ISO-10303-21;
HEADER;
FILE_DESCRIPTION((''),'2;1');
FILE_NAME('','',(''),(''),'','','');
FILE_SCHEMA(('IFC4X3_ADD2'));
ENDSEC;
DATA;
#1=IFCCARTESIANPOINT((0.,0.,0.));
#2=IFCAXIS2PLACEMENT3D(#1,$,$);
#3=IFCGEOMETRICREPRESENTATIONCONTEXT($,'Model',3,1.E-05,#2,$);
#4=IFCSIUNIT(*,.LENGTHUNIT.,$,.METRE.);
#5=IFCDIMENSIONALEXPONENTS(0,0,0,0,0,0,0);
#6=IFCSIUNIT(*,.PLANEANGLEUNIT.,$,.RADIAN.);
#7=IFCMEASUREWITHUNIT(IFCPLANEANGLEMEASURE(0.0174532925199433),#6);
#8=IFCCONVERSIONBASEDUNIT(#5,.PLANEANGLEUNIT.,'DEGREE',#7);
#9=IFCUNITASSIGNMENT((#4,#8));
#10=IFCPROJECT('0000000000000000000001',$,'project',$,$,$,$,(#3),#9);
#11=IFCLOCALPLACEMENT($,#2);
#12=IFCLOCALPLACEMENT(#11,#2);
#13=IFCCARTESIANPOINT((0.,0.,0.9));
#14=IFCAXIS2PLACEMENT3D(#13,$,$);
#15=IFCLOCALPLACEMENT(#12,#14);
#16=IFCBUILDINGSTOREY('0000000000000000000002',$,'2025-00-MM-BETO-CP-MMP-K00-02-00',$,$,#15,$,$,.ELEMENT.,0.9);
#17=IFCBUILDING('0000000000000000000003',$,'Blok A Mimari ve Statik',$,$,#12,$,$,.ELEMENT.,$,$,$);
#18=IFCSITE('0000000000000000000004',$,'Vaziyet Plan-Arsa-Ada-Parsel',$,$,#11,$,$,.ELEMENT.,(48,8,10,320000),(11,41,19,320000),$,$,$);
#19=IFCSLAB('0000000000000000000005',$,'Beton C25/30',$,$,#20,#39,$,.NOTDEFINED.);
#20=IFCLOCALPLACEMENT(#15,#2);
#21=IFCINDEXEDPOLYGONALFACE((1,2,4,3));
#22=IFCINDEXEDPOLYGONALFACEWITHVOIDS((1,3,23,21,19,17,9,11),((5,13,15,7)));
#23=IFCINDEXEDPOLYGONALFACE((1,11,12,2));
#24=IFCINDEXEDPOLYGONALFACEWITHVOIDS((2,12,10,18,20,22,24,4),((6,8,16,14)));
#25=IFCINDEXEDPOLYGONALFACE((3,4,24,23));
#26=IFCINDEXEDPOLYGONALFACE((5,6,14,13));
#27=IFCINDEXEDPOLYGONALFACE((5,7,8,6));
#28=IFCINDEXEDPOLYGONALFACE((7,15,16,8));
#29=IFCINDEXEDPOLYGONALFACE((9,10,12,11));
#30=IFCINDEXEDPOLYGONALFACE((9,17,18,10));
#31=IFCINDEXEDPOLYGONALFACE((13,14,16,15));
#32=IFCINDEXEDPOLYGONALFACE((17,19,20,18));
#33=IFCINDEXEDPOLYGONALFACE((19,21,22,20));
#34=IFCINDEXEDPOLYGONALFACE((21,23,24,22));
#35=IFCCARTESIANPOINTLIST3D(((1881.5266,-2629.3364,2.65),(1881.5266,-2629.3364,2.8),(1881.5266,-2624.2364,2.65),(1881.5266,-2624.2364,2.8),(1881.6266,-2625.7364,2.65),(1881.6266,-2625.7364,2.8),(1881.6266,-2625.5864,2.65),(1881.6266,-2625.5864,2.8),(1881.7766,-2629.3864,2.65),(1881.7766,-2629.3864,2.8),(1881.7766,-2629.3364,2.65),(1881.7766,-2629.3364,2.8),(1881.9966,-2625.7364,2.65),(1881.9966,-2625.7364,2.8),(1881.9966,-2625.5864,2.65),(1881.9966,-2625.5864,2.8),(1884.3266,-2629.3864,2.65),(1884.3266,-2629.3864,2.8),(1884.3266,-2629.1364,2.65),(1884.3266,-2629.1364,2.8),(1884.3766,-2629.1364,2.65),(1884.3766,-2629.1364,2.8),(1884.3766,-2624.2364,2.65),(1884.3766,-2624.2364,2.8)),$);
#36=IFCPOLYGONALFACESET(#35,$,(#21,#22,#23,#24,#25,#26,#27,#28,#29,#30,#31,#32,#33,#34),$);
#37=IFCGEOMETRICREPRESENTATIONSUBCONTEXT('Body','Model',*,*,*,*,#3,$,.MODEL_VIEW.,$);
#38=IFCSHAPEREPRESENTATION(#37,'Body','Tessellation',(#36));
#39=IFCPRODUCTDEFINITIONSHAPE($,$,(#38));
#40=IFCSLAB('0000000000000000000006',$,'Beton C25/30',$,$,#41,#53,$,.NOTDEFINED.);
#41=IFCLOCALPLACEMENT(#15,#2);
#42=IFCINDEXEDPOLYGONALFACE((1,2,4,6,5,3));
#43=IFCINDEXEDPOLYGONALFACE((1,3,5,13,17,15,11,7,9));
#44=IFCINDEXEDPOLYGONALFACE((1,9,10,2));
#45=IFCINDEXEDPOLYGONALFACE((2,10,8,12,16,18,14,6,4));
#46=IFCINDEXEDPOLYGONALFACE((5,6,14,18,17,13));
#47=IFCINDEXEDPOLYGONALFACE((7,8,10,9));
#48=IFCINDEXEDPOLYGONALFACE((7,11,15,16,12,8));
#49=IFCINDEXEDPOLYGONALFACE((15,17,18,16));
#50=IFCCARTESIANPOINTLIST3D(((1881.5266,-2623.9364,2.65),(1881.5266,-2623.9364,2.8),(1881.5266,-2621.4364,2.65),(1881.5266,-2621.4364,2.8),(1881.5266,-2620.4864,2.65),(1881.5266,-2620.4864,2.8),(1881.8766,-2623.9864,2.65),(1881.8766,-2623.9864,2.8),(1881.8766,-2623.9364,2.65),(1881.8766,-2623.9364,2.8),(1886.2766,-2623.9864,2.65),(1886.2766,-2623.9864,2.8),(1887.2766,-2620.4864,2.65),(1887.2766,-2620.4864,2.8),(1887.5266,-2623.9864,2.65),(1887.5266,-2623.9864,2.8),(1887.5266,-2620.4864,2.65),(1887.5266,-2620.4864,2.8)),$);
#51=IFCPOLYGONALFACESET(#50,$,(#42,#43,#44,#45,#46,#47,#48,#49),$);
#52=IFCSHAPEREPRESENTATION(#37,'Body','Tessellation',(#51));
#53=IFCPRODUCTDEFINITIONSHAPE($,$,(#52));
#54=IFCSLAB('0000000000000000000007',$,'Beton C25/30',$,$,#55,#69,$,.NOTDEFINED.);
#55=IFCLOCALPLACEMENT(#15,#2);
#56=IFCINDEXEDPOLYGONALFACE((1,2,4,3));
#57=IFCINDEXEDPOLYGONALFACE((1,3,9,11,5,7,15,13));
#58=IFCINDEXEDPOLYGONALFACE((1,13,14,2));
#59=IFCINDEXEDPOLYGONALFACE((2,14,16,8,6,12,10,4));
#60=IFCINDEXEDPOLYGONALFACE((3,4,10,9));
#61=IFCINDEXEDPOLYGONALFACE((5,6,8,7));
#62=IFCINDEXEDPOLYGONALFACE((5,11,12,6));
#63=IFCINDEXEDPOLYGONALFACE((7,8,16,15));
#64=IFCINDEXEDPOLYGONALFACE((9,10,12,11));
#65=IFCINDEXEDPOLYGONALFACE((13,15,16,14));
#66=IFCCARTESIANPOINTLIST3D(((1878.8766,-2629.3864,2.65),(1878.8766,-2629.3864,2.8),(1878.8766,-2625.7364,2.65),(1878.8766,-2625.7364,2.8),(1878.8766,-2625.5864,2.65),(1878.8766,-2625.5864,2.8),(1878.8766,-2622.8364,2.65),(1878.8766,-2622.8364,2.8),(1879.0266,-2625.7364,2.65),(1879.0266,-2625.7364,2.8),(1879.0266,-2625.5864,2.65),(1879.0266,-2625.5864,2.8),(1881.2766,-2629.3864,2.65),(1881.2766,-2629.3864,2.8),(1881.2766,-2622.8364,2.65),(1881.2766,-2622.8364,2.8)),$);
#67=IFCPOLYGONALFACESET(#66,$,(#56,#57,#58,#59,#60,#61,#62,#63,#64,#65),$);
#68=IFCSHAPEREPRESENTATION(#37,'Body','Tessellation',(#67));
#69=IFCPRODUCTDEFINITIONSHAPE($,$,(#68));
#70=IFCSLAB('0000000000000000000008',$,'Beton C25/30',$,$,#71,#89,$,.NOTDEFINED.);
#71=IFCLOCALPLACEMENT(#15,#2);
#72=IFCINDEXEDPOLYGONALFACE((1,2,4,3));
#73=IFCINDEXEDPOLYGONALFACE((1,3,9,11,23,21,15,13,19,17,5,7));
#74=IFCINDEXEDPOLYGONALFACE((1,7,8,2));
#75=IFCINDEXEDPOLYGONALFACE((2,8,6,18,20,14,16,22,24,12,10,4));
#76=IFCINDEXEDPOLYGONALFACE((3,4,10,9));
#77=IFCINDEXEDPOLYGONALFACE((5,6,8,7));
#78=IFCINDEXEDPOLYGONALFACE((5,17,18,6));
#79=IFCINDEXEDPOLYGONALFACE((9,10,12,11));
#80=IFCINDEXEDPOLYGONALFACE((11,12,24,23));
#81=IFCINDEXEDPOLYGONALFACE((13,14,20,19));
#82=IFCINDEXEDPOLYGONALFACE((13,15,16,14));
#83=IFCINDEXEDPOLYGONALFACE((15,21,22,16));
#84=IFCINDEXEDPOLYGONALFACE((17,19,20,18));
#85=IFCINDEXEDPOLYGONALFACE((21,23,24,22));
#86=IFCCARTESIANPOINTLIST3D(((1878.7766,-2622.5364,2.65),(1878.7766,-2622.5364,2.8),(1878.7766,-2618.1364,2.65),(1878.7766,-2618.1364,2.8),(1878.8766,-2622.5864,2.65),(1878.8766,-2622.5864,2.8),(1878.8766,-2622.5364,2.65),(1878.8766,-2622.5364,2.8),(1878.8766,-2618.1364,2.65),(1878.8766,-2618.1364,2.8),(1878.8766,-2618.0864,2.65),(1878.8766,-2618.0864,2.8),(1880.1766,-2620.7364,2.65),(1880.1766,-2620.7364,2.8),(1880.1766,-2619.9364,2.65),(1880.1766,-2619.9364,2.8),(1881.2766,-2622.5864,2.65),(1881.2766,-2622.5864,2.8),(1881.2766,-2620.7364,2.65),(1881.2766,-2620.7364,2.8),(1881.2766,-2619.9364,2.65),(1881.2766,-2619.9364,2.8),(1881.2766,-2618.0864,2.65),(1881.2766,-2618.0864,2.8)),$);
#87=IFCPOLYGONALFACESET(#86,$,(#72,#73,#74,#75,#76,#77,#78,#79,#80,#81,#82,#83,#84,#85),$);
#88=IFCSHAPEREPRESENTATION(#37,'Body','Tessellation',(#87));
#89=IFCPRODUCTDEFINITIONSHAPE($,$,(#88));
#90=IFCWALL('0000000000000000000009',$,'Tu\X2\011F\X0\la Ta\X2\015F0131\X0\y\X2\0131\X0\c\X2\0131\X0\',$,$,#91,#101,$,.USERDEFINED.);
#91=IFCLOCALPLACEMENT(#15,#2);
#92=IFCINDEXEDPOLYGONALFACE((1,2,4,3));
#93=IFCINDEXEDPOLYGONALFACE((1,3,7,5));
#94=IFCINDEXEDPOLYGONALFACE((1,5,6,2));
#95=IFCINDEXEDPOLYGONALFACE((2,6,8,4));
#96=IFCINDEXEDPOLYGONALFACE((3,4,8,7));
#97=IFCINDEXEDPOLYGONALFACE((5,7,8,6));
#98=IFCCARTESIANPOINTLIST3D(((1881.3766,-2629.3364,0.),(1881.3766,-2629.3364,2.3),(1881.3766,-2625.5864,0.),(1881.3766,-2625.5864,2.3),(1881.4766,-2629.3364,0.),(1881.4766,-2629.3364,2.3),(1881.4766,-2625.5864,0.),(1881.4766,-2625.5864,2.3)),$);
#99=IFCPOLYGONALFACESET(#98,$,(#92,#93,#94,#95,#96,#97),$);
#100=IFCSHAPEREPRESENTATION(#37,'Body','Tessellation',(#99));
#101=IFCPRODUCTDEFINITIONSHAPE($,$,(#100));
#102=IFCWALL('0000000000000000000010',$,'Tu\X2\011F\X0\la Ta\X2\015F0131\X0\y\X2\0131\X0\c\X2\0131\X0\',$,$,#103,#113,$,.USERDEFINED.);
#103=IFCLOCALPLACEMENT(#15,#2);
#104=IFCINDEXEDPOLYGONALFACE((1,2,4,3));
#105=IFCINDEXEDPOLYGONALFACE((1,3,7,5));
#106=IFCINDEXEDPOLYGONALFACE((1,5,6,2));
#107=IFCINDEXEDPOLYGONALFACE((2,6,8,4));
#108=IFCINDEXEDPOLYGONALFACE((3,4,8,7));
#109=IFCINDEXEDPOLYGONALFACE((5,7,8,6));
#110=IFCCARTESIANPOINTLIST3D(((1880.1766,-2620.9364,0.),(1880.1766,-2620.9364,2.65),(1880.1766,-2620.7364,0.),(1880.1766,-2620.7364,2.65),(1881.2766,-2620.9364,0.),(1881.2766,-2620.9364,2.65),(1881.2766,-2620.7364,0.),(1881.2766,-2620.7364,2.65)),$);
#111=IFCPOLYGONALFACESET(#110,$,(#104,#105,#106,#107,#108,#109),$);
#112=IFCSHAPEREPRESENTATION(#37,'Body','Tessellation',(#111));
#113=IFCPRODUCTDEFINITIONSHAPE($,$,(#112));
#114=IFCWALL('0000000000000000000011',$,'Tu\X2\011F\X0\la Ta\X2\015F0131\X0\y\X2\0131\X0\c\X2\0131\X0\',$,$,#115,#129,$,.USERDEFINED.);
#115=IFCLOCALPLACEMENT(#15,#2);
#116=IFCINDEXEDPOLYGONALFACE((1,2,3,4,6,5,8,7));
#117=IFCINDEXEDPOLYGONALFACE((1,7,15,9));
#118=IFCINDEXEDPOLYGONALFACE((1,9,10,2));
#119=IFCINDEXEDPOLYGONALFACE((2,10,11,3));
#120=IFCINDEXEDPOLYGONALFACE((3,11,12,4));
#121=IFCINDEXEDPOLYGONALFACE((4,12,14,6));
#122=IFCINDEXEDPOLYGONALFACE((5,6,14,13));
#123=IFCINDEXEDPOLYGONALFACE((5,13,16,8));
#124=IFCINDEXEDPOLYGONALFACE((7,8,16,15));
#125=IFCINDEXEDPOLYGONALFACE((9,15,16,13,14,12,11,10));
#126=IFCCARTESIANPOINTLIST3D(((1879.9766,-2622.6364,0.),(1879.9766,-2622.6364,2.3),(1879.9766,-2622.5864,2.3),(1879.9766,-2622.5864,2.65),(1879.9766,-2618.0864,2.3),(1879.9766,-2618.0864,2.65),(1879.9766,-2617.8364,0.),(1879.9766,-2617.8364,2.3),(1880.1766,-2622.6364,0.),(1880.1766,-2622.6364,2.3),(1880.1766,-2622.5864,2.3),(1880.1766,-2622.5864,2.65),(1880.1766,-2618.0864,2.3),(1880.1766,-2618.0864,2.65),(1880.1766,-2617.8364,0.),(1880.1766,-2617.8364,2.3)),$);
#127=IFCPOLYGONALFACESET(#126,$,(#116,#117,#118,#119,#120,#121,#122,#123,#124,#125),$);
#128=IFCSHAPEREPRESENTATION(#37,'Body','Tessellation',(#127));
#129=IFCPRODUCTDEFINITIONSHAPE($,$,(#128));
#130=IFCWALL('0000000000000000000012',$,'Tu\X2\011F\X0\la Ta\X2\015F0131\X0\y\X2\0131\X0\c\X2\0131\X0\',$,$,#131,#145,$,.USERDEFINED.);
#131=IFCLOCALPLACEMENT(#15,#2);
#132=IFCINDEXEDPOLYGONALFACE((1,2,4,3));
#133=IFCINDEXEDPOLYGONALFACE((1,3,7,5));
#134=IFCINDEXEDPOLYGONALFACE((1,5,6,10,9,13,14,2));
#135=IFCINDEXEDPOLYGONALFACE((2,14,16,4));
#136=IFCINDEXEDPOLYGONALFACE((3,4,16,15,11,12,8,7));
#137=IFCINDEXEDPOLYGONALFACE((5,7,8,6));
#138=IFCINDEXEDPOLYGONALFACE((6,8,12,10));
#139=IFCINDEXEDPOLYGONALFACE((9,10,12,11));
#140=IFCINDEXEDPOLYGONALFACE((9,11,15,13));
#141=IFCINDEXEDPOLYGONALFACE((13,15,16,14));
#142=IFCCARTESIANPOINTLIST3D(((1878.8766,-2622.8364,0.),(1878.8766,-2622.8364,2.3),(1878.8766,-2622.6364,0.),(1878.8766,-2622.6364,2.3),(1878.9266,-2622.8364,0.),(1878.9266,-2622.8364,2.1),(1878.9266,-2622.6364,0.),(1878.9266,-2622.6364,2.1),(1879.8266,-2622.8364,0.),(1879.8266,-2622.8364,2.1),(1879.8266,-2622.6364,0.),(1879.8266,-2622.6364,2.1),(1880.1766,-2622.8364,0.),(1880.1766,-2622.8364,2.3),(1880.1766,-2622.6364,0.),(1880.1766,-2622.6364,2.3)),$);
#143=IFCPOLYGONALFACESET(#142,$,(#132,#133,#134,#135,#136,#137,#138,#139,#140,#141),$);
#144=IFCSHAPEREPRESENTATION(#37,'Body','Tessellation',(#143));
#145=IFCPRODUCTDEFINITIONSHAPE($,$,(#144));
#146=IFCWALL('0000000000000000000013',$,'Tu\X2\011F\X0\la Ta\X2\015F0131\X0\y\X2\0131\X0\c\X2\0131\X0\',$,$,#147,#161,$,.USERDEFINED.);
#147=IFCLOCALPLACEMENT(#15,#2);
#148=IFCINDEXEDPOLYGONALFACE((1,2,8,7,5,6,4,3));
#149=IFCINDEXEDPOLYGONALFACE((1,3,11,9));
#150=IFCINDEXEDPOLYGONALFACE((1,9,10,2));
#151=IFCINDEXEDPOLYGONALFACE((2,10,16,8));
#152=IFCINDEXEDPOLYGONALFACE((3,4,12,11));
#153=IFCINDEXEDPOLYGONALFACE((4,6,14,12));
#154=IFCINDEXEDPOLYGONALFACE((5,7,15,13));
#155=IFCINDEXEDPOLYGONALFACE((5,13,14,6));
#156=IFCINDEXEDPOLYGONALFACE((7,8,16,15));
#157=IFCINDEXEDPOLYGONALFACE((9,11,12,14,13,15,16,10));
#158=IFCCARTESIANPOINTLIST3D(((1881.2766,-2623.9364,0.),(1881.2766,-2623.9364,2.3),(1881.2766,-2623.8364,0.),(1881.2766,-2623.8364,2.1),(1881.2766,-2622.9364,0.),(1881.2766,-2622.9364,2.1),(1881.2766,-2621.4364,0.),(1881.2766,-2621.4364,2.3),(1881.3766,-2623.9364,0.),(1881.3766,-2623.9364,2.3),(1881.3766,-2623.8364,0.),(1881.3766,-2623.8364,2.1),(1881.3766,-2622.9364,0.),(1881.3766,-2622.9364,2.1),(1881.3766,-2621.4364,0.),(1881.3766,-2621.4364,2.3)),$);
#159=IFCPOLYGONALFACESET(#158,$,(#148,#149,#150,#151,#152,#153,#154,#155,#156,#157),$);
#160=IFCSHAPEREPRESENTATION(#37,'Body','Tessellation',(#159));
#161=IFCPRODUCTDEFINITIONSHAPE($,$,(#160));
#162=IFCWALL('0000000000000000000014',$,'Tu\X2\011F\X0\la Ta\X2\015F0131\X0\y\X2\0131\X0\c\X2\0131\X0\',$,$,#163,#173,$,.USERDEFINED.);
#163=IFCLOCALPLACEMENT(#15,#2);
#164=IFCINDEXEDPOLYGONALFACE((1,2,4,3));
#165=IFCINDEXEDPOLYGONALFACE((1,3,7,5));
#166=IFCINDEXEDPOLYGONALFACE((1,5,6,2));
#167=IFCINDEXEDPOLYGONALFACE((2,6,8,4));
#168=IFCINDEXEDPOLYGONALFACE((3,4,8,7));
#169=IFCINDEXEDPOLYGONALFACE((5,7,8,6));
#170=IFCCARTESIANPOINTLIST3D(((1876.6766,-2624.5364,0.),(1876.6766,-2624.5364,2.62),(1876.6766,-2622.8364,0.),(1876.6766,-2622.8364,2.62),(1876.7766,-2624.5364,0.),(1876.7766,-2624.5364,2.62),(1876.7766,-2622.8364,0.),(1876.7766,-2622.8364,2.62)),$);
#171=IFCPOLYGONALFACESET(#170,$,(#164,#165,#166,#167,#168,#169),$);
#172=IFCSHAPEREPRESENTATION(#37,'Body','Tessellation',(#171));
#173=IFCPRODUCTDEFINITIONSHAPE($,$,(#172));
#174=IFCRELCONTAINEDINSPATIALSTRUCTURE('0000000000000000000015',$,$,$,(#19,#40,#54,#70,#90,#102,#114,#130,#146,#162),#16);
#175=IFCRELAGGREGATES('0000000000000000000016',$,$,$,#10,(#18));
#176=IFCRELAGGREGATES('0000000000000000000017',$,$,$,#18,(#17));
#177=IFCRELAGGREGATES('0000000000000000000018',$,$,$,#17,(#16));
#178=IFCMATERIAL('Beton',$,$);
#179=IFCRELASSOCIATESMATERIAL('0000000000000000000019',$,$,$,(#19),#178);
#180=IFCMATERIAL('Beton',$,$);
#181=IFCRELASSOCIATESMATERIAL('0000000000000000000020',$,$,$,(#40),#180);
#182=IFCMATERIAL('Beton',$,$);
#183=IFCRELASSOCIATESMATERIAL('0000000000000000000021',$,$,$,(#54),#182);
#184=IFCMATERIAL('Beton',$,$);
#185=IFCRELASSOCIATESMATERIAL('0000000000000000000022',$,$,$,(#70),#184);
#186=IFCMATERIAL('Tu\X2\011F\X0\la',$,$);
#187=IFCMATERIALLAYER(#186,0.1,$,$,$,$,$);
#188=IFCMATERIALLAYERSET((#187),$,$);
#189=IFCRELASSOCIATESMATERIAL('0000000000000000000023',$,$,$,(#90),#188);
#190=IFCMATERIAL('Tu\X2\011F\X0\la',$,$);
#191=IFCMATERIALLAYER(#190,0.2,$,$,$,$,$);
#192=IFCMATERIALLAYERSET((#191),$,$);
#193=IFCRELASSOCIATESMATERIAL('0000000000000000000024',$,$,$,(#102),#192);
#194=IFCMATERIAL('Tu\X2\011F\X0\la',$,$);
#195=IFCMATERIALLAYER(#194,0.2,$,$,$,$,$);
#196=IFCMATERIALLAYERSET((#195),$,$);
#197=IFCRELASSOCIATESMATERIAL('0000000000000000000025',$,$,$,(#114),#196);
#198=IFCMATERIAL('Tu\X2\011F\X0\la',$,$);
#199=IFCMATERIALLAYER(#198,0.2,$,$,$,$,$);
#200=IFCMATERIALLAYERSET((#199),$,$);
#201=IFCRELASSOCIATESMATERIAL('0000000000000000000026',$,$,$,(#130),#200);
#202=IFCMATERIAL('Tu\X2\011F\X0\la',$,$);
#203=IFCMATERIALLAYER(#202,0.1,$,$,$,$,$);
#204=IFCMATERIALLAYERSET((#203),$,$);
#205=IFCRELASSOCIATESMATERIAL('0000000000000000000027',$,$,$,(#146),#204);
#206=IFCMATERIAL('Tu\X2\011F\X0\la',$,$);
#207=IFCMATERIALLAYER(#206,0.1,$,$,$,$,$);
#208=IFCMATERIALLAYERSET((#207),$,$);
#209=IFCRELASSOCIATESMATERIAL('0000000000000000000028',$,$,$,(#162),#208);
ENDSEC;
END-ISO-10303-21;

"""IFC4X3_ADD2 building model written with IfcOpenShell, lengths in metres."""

from ifc_helpers import new_model, entity, si_unit, converted_unit, frame, frame_2d, origin, origin_with_axes, place, context, subcontext, project, spatial, polyline, rectangle, outline, extrude, clip, bounded_halfspace, material, layer, layer_set, layer_usage, element, save


model = new_model("IFC4X3_ADD2")

# Units and contexts
model_context = context("Model", 3, precision=1e-05, world=origin())
body_context = subcontext(model_context, "Body", "Model", "MODEL_VIEW")
ifc_project = project(units=[si_unit("LENGTHUNIT", "METRE"), converted_unit("PLANEANGLEUNIT", "DEGREE", entity("IfcPlaneAngleMeasure", 0.0174532925199433), si_unit("PLANEANGLEUNIT", "RADIAN"), dimensions=[0, 0, 0, 0, 0, 0, 0])], contexts=[model_context])

# Site, building, storey
site_placement = place(None, origin())
site = spatial("IfcSite", under=ifc_project, at=site_placement, Name="Vaziyet Plan-Arsa-Ada-Parsel", CompositionType="ELEMENT", RefLatitude=(48, 8, 10, 320000), RefLongitude=(11, 41, 19, 320000))
building_placement = place(site_placement, origin())
building = spatial("IfcBuilding", under=site, at=building_placement, Name="Blok A Mimari ve Statik", CompositionType="ELEMENT")
storey_placement = place(building_placement, frame((0.0, 0.0, 0.9)))
storey = spatial("IfcBuildingStorey", under=building, at=storey_placement, Name="2025-00-MM-BETO-CP-MMP-K00-02-00", CompositionType="ELEMENT", Elevation=0.9)

# Slabs
ifc_material_1 = material(Name="Beton")
slab_1_placement = place(storey_placement, frame((1881.5266, -2629.3864, 2.65)))
element("IfcSlab", 1, at=slab_1_placement, inside=storey, material=ifc_material_1, Name="Beton C25/30", PredefinedType="NOTDEFINED", context=body_context, shape_type="SweptSolid", body=[
    extrude(outline(polyline([(0.0, 5.15), (0.0, 0.05), (0.25, 0.05), (0.25, 0.0), (2.8, 0.0), (2.8, 0.25), (2.85, 0.25), (2.85, 5.15), (0.0, 5.15)]), holes=[polyline([(0.1, 3.8), (0.47, 3.8), (0.47, 3.65), (0.1, 3.65), (0.1, 3.8)])]), origin_with_axes(), (0.0, 0.0, 1.0), 0.15),
])
ifc_material_2 = material(Name="Beton")
slab_2_placement = place(storey_placement, frame((1881.5266, -2623.9864, 2.65)))
element("IfcSlab", 2, at=slab_2_placement, inside=storey, material=ifc_material_2, Name="Beton C25/30", PredefinedType="NOTDEFINED", context=body_context, shape_type="SweptSolid", body=[
    extrude(outline(polyline([(0.0, 3.5), (0.0, 2.55), (0.0, 0.05), (0.35, 0.05), (0.35, 0.0), (4.75, 0.0), (6.0, 0.0), (6.0, 3.5), (5.75, 3.5), (0.0, 3.5)])), origin_with_axes(), (0.0, 0.0, 1.0), 0.15),
])
ifc_material_3 = material(Name="Beton")
slab_3_placement = place(storey_placement, frame((1878.8766, -2629.3864, 2.65)))
element("IfcSlab", 3, at=slab_3_placement, inside=storey, material=ifc_material_3, Name="Beton C25/30", PredefinedType="NOTDEFINED", context=body_context, shape_type="SweptSolid", body=[
    extrude(outline(polyline([(0.0, 3.8), (0.15, 3.8), (0.15, 3.65), (0.0, 3.65), (0.0, 0.0), (2.4, 0.0), (2.4, 6.55), (0.0, 6.55), (0.0, 3.8)])), origin_with_axes(), (0.0, 0.0, 1.0), 0.15),
])

# Slab, opening
ifc_material_4 = material(Name="Beton")
slab_4_placement = place(storey_placement, frame((1878.7766, -2622.5864, 2.65)))
slab_4 = element("IfcSlab", 4, at=slab_4_placement, inside=storey, material=ifc_material_4, Name="Beton C25/30", PredefinedType="NOTDEFINED", context=body_context, shape_type="SweptSolid", body=[
    extrude(outline(polyline([(0.1, 4.45), (0.0, 4.45), (0.0, 0.05), (0.1, 0.05), (0.1, 0.0), (2.5, 0.0), (2.5, 4.5), (0.1, 4.5), (0.1, 4.45)])), origin_with_axes(), (0.0, 0.0, 1.0), 0.15),
])
opening_1_placement = place(slab_4_placement, frame((1.4, 1.85, 0.0)))
element("IfcOpeningElement", 5, at=opening_1_placement, cuts=slab_4, PredefinedType="OPENING", context=body_context, shape_type="SweptSolid", body=[
    extrude(rectangle(XDim=1.1, YDim=0.8, at=frame_2d((0.0, 0.0), x_axis=(-1.0, 0.0))), frame((0.55, 0.4, 0.0), z_axis=(0.0, 0.0, 1.0), x_axis=(1.0, 0.0, 0.0)), (0.0, 0.0, 1.0), 0.15),
])

# Walls
ifc_material_5 = material(Name="Tuğla")
ifc_layer_1 = layer(ifc_material_5, 0.1)
ifc_layer_set_1 = layer_set([ifc_layer_1])
ifc_layer_usage_1 = layer_usage(ifc_layer_set_1, "AXIS2", "POSITIVE", 0.0)
wall_1_placement = place(storey_placement, frame((1881.3766, -2625.5864, 0.0), z_axis=(0.0, 0.0, 1.0), x_axis=(0.0, -1.0, 0.0)))
element("IfcWall", 6, at=wall_1_placement, inside=storey, material=ifc_layer_usage_1, Name="Tuğla Taşıyıcı", PredefinedType="USERDEFINED", context=body_context, shape_type="SweptSolid", body=[
    extrude(rectangle(XDim=3.75, YDim=0.1, at=frame_2d((1.875, 0.05), x_axis=(1.0, 0.0))), origin_with_axes(), (0.0, 0.0, 1.0), 2.3),
])
ifc_material_6 = material(Name="Tuğla")
ifc_layer_2 = layer(ifc_material_6, 0.2)
ifc_layer_set_2 = layer_set([ifc_layer_2])
ifc_layer_usage_2 = layer_usage(ifc_layer_set_2, "AXIS2", "POSITIVE", 0.0)
wall_2_placement = place(storey_placement, frame((1880.1766, -2620.9364, 0.0)))
element("IfcWall", 7, at=wall_2_placement, inside=storey, material=ifc_layer_usage_2, Name="Tuğla Taşıyıcı", PredefinedType="USERDEFINED", context=body_context, shape_type="SweptSolid", body=[
    extrude(rectangle(XDim=1.1, YDim=0.2, at=frame_2d((0.55, 0.1), x_axis=(1.0, 0.0))), origin_with_axes(), (0.0, 0.0, 1.0), 2.65),
])
ifc_material_7 = material(Name="Tuğla")
ifc_layer_3 = layer(ifc_material_7, 0.2)
ifc_layer_set_3 = layer_set([ifc_layer_3])
ifc_layer_usage_3 = layer_usage(ifc_layer_set_3, "AXIS2", "POSITIVE", 0.0)
wall_3_placement = place(storey_placement, frame((1880.1766, -2622.6364, 0.0), z_axis=(0.0, 0.0, 1.0), x_axis=(0.0, 1.0, 0.0)))
element("IfcWall", 8, at=wall_3_placement, inside=storey, material=ifc_layer_usage_3, Name="Tuğla Taşıyıcı", PredefinedType="USERDEFINED", context=body_context, shape_type="Clipping", body=[
    clip(clip(extrude(rectangle(XDim=4.8, YDim=0.2, at=frame_2d((2.4, 0.1), x_axis=(1.0, 0.0))), origin_with_axes(), (0.0, 0.0, 1.0), 2.65), bounded_halfspace(frame((4.675, 0.1, 2.3), z_axis=(0.0, 0.0, -1.0), x_axis=(-1.0, 0.0, 0.0)), True, origin_with_axes(), polyline([(4.8, 0.2), (4.55, 0.2), (4.55, 0.0), (4.8, 0.0), (4.8, 0.2)]))), bounded_halfspace(frame((0.025, 0.1, 2.3), z_axis=(0.0, 0.0, -1.0), x_axis=(0.0, -1.0, 0.0)), True, origin_with_axes(), polyline([(0.0, 0.2), (0.0, 0.0), (0.05, 0.0), (0.05, 0.2), (0.0, 0.2)]))),
])

# Walls, openings
ifc_material_8 = material(Name="Tuğla")
ifc_layer_4 = layer(ifc_material_8, 0.2)
ifc_layer_set_4 = layer_set([ifc_layer_4])
ifc_layer_usage_4 = layer_usage(ifc_layer_set_4, "AXIS2", "POSITIVE", 0.0)
wall_4_placement = place(storey_placement, frame((1878.8766, -2622.8364, 0.0), z_axis=(0.0, 0.0, 1.0), x_axis=(1.0, 0.000001, 0.0)))
wall_4 = element("IfcWall", 9, at=wall_4_placement, inside=storey, material=ifc_layer_usage_4, Name="Tuğla Taşıyıcı", PredefinedType="USERDEFINED", context=body_context, shape_type="SweptSolid", body=[
    extrude(rectangle(XDim=1.3, YDim=0.2, at=frame_2d((0.65, 0.1), x_axis=(1.0, 0.0))), origin_with_axes(), (0.0, 0.0, 1.0), 2.3),
])
opening_2_placement = place(wall_4_placement, frame((0.05, 0.0, 0.0), z_axis=(0.0, 1.0, 0.0), x_axis=(0.0, 0.0, 1.0)))
element("IfcOpeningElement", 10, at=opening_2_placement, cuts=wall_4, PredefinedType="OPENING", context=body_context, shape_type="SweptSolid", body=[
    extrude(outline(polyline([(2.1, 0.9), (2.1, 0.0), (0.0, 0.0), (0.0, 0.9), (2.1, 0.9)])), origin_with_axes(), (0.0, 0.0, 1.0), 0.2),
])
ifc_material_9 = material(Name="Tuğla")
ifc_layer_5 = layer(ifc_material_9, 0.1)
ifc_layer_set_5 = layer_set([ifc_layer_5])
ifc_layer_usage_5 = layer_usage(ifc_layer_set_5, "AXIS2", "POSITIVE", 0.0)
wall_5_placement = place(storey_placement, frame((1881.2766, -2621.4364, 0.0), z_axis=(0.0, 0.0, 1.0), x_axis=(0.0, -1.0, 0.0)))
wall_5 = element("IfcWall", 11, at=wall_5_placement, inside=storey, material=ifc_layer_usage_5, Name="Tuğla Taşıyıcı", PredefinedType="USERDEFINED", context=body_context, shape_type="SweptSolid", body=[
    extrude(rectangle(XDim=2.5, YDim=0.1, at=frame_2d((1.25, 0.05), x_axis=(1.0, 0.0))), origin_with_axes(), (0.0, 0.0, 1.0), 2.3),
])
opening_3_placement = place(wall_5_placement, frame((2.4, 0.1, 0.0), z_axis=(0.0, -1.0, 0.0), x_axis=(0.0, 0.0, 1.0)))
element("IfcOpeningElement", 12, at=opening_3_placement, cuts=wall_5, PredefinedType="OPENING", context=body_context, shape_type="SweptSolid", body=[
    extrude(outline(polyline([(2.1, 0.9), (2.1, 0.0), (0.0, 0.0), (0.0, 0.9), (2.1, 0.9)])), origin_with_axes(), (0.0, 0.0, 1.0), 0.1),
])

# Wall
ifc_material_10 = material(Name="Tuğla")
ifc_layer_6 = layer(ifc_material_10, 0.1)
ifc_layer_set_6 = layer_set([ifc_layer_6])
ifc_layer_usage_6 = layer_usage(ifc_layer_set_6, "AXIS2", "POSITIVE", 0.0)
wall_6_placement = place(storey_placement, frame((1876.6766, -2622.8364, 0.0), z_axis=(0.0, 0.0, 1.0), x_axis=(0.0, -1.0, 0.0)))
element("IfcWall", 13, at=wall_6_placement, inside=storey, material=ifc_layer_usage_6, Name="Tuğla Taşıyıcı", PredefinedType="USERDEFINED", context=body_context, shape_type="SweptSolid", body=[
    extrude(rectangle(XDim=1.7, YDim=0.1, at=frame_2d((0.85, 0.05), x_axis=(1.0, 0.0))), origin_with_axes(), (0.0, 0.0, 1.0), 2.62),
])

save(model, "model.ifc")
